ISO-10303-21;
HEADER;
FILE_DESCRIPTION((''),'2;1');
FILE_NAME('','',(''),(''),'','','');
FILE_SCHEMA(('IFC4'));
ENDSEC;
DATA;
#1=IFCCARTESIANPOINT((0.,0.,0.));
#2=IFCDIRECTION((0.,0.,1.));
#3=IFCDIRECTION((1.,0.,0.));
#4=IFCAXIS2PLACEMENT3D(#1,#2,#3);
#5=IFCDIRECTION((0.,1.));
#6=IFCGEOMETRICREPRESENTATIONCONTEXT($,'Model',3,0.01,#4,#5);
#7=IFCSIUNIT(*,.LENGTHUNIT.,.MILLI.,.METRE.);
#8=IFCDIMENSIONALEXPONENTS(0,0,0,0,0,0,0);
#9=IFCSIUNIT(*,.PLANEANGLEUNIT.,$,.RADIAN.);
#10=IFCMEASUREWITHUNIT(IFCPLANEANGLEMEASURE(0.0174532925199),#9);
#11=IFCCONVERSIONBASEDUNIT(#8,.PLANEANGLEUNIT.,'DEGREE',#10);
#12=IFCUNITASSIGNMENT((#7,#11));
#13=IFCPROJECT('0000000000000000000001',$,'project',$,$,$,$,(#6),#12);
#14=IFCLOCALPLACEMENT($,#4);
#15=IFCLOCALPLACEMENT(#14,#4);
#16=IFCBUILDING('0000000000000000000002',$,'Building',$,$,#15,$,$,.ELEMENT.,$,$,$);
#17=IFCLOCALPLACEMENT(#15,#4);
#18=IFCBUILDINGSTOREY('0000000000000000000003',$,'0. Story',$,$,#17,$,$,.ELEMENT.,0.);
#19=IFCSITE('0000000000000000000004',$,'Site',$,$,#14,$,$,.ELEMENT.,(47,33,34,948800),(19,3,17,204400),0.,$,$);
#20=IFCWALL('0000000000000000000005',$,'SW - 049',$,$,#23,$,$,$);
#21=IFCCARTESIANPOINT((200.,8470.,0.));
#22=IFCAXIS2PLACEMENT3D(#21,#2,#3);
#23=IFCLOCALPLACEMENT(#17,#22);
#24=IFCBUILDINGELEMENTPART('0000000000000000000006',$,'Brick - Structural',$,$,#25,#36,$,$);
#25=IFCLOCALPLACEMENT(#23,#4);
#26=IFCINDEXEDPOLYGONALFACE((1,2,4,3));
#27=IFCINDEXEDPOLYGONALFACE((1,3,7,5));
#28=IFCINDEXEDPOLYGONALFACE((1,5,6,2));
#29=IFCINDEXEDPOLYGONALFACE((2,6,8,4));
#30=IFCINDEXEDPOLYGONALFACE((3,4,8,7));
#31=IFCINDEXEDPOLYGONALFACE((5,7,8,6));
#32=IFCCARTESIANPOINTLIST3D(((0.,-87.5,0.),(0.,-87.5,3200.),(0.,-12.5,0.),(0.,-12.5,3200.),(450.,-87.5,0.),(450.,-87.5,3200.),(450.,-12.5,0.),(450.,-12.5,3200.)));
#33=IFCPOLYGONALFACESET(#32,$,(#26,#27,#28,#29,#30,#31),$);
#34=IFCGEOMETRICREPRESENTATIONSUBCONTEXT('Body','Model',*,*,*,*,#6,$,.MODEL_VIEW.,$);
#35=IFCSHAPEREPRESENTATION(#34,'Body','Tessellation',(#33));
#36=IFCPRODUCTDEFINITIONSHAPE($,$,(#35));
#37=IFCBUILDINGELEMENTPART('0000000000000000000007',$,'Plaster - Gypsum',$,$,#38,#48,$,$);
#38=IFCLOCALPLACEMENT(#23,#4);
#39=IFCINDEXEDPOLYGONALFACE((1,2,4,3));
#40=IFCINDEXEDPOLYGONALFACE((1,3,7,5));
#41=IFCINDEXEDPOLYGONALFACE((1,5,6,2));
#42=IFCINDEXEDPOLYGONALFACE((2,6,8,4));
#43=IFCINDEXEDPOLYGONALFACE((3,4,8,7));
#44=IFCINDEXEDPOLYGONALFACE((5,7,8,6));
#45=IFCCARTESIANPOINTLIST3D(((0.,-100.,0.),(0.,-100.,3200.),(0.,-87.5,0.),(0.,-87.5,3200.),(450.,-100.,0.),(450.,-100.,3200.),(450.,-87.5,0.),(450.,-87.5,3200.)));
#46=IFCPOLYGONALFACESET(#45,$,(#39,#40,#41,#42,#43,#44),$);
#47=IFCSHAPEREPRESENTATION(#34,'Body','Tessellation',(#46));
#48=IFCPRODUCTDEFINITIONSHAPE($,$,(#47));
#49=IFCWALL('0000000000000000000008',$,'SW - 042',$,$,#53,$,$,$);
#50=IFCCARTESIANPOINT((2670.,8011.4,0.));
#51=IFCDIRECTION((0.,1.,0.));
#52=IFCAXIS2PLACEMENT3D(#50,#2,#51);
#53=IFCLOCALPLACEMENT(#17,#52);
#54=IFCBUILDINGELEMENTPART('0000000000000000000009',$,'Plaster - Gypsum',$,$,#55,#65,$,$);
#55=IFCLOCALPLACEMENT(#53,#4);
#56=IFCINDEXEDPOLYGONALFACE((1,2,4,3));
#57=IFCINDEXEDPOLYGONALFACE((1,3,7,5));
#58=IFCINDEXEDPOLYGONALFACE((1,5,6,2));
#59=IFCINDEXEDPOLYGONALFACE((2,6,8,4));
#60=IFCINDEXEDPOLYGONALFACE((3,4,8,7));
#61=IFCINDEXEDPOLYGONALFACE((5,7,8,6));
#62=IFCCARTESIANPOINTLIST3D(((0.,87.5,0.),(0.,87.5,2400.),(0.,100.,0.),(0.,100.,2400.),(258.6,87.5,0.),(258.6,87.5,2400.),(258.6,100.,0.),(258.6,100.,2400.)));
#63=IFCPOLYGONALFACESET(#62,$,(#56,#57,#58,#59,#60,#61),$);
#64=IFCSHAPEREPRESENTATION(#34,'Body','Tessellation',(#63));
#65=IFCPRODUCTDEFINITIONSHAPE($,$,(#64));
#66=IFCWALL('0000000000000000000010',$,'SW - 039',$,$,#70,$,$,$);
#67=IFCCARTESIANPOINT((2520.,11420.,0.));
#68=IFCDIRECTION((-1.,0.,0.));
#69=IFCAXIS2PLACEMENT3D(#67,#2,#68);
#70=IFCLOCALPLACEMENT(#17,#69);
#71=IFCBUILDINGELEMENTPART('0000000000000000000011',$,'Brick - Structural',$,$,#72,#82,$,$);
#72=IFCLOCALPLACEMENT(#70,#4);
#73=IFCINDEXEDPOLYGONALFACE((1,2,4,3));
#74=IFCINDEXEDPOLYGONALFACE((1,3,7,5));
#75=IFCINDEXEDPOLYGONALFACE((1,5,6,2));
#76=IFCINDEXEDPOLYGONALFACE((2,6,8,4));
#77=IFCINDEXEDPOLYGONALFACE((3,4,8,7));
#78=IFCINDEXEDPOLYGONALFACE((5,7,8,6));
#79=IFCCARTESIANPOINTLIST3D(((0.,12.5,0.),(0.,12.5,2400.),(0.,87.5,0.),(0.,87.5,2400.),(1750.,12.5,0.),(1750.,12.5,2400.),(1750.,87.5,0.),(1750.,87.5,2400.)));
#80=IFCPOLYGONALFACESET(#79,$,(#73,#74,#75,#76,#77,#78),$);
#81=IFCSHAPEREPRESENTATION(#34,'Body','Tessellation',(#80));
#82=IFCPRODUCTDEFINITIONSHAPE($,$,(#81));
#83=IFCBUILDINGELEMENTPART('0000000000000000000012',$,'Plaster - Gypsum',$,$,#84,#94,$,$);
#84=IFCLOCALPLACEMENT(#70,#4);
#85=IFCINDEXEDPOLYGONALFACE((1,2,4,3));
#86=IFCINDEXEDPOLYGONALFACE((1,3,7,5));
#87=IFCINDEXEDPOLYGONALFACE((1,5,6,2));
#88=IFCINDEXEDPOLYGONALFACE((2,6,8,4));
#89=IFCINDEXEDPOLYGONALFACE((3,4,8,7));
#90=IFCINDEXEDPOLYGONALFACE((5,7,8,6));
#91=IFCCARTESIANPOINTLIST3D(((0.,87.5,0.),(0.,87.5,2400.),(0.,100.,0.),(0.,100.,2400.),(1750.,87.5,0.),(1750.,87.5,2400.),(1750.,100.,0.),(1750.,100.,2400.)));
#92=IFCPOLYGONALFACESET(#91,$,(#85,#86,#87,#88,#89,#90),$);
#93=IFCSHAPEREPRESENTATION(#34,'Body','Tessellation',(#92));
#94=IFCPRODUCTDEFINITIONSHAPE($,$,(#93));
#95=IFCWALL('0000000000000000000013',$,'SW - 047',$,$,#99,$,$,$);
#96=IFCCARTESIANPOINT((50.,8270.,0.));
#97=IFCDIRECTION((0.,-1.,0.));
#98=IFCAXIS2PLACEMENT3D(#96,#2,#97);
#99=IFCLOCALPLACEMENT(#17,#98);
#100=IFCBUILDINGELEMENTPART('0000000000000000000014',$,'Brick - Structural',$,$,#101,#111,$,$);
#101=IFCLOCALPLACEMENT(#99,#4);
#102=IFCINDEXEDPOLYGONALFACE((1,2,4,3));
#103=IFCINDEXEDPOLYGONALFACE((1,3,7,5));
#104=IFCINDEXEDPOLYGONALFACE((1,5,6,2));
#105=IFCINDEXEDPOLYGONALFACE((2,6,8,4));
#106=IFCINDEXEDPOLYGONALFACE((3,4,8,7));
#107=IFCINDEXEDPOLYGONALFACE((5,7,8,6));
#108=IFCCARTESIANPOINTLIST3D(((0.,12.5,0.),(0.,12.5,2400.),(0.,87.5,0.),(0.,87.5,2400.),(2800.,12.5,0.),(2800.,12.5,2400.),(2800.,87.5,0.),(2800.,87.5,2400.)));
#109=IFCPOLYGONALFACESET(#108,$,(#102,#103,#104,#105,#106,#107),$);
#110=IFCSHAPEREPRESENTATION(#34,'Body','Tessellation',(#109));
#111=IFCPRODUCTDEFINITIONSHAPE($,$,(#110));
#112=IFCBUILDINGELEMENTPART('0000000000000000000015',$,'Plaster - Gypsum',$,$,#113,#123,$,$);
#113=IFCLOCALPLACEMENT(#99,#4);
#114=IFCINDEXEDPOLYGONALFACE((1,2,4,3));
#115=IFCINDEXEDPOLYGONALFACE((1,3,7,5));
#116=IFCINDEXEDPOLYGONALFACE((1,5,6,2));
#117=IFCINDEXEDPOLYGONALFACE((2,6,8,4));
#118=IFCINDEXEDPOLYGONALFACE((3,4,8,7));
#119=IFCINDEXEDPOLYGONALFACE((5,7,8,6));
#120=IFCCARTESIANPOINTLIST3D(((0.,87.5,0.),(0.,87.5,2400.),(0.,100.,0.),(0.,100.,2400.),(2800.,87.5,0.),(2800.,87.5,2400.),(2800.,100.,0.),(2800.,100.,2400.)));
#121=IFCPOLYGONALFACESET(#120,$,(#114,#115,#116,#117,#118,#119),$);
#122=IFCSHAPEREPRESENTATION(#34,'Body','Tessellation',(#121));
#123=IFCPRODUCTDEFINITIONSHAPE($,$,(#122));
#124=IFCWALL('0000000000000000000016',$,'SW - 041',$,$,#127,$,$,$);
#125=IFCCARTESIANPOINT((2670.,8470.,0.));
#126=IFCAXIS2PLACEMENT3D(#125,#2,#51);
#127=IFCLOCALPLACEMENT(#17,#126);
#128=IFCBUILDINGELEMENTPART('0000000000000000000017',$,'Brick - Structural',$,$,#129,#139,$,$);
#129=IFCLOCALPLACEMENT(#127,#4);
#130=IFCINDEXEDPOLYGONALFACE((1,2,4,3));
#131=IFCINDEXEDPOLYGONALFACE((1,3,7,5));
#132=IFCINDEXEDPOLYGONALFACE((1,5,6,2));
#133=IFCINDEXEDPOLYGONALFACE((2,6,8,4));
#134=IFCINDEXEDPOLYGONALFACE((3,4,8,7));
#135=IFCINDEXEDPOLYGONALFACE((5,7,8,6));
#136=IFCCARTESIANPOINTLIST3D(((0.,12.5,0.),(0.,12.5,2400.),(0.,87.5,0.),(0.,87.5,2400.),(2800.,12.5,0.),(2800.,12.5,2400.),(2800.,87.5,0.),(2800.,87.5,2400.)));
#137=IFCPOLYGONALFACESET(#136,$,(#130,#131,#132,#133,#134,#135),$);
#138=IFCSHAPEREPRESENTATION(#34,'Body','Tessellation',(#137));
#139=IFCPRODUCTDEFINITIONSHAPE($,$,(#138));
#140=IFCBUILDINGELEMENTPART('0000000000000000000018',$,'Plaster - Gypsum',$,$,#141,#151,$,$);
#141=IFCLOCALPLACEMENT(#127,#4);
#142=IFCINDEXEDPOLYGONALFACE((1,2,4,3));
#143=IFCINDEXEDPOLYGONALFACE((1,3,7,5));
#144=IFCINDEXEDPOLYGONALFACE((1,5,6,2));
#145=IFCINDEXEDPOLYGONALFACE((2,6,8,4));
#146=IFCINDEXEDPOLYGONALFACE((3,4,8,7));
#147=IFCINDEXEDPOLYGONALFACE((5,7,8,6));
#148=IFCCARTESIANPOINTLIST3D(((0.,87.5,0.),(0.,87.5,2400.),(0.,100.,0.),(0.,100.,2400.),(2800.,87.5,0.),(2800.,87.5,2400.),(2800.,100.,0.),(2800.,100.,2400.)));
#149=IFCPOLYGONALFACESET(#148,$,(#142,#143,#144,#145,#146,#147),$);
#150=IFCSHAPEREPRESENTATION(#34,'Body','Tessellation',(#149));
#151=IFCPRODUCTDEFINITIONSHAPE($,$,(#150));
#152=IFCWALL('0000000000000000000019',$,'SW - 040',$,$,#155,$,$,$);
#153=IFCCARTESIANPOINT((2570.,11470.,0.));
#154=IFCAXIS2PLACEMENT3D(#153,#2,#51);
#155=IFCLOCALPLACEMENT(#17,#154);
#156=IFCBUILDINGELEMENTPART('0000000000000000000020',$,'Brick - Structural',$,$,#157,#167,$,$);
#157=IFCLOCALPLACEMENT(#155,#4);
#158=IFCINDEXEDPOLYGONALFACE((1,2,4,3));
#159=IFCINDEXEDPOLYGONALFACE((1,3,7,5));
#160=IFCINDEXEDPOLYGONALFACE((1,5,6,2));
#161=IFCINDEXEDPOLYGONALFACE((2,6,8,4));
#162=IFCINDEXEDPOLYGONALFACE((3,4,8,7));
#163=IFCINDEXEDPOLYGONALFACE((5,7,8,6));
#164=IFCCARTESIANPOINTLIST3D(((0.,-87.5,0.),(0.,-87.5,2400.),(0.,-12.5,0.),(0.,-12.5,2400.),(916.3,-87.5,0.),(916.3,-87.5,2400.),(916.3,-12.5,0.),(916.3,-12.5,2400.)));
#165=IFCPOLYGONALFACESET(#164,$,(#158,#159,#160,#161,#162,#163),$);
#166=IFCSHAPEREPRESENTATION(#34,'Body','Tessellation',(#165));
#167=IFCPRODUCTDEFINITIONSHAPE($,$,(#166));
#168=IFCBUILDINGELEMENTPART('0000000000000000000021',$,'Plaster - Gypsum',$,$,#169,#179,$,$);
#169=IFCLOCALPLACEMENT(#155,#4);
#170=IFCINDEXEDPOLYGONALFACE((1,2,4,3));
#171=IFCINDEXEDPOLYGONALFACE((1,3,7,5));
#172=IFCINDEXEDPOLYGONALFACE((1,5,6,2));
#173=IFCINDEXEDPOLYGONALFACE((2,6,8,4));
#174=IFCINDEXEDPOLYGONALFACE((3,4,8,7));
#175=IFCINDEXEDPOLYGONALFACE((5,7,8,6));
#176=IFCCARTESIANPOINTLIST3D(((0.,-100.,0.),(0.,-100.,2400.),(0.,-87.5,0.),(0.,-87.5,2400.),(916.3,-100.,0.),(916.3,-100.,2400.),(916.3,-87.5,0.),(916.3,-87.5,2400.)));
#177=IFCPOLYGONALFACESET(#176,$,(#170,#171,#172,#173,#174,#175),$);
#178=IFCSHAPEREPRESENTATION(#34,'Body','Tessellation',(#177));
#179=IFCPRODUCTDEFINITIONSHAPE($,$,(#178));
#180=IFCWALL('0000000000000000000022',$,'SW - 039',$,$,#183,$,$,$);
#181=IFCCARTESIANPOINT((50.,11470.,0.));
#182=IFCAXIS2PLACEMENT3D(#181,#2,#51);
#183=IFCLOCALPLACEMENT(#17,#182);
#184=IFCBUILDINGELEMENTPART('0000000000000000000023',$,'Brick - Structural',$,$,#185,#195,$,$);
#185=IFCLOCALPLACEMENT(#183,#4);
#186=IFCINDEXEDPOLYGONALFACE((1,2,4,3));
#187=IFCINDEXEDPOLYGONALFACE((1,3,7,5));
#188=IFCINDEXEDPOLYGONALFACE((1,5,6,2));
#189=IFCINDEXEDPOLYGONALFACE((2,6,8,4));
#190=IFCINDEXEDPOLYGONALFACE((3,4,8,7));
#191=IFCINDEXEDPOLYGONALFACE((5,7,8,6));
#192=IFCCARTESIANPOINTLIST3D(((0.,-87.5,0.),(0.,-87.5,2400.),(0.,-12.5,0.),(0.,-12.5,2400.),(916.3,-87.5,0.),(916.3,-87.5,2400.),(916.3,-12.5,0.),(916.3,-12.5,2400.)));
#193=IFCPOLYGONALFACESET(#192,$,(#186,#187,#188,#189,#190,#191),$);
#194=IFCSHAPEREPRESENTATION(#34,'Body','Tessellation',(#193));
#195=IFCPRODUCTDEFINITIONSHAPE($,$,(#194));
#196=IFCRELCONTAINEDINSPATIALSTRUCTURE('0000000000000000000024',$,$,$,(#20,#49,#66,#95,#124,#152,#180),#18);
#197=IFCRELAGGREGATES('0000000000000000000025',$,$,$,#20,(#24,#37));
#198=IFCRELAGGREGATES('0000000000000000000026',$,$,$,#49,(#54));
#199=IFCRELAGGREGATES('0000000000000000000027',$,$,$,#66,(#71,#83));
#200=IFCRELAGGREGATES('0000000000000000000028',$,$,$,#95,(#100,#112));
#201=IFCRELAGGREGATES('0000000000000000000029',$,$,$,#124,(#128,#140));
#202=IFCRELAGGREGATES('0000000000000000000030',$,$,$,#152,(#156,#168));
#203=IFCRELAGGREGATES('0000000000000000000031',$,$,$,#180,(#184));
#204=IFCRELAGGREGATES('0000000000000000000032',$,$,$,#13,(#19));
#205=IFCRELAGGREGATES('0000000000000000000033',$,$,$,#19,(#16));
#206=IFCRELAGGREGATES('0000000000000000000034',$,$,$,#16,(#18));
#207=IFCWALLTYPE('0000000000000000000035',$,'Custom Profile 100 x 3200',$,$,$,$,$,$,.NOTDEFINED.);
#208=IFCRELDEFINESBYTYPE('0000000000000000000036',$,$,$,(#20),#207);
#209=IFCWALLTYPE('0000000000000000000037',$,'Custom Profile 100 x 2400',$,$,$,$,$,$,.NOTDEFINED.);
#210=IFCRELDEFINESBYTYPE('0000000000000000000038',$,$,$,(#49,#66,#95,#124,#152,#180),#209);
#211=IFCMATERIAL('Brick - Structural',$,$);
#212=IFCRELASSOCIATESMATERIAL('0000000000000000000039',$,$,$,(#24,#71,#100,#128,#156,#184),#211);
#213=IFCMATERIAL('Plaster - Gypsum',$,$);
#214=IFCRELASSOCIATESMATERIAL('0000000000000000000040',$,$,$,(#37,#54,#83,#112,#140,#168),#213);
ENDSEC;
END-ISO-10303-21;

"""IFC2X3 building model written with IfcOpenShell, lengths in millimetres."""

from ifc_helpers import new_model, entity, si_unit, converted_unit, direction, frame, origin_with_axes, place, context, subcontext, project, spatial, polyline, outline, extrude, material, type_object, element, aggregate, save


model = new_model("IFC2X3")

# Units and contexts
model_context = context("Model", 3, precision=0.01, world=origin_with_axes(), true_north=direction((0.0, 1.0)))
body_context = subcontext(model_context, "Body", "Model", "MODEL_VIEW")
ifc_project = project(units=[si_unit("LENGTHUNIT", "METRE", prefix="MILLI"), converted_unit("PLANEANGLEUNIT", "DEGREE", entity("IfcPlaneAngleMeasure", 0.0174532925199), si_unit("PLANEANGLEUNIT", "RADIAN"), dimensions=[0, 0, 0, 0, 0, 0, 0])], contexts=[model_context])

# Site, building, storey
site_placement = place(None, origin_with_axes())
site = spatial("IfcSite", under=ifc_project, at=site_placement, Name="Site", CompositionType="ELEMENT", RefLatitude=(47, 33, 34, 948800), RefLongitude=(19, 3, 17, 204400), RefElevation=0.0)
building_placement = place(site_placement, origin_with_axes())
building = spatial("IfcBuilding", under=site, at=building_placement, Name="Building", CompositionType="ELEMENT")
storey_placement = place(building_placement, origin_with_axes())
storey = spatial("IfcBuildingStorey", under=building, at=storey_placement, Name="0. Story", CompositionType="ELEMENT", Elevation=0.0)

# Wall, building element parts
wall_type_1 = type_object("IfcWallType", Name="Custom Profile 100 x 3200", PredefinedType="NOTDEFINED")
wall_1_placement = place(storey_placement, frame((200.0, 8470.0, 0.0), z_axis=(0.0, 0.0, 1.0), x_axis=(1.0, 0.0, 0.0)))
wall_1 = element("IfcWall", 1, at=wall_1_placement, inside=storey, type_object=wall_type_1, Name="SW - 049")
ifc_material_1 = material(Name="Plaster - Gypsum")
ifc_material_2 = material(Name="Brick - Structural")
building_element_part_1_placement = place(wall_1_placement, origin_with_axes())
building_element_part_1 = element("IfcBuildingElementPart", 2, at=building_element_part_1_placement, material=ifc_material_2, Name="Brick - Structural", context=body_context, shape_type="SweptSolid", body=[
    extrude(outline(polyline([(-87.5, 0.0), (-12.5, 0.0), (-12.5, 3200.0), (-87.5, 3200.0), (-87.5, 0.0)])), frame((0.0, 0.0, 0.0), z_axis=(1.0, 0.0, 0.0), x_axis=(0.0, 1.0, 0.0)), (0.0, 0.0, 1.0), 450.0),
])
building_element_part_2_placement = place(wall_1_placement, origin_with_axes())
building_element_part_2 = element("IfcBuildingElementPart", 3, at=building_element_part_2_placement, material=ifc_material_1, Name="Plaster - Gypsum", context=body_context, shape_type="SweptSolid", body=[
    extrude(outline(polyline([(-100.0, 3200.0), (-100.0, 0.0), (-87.5, 0.0), (-87.5, 3200.0), (-100.0, 3200.0)])), frame((0.0, 0.0, 0.0), z_axis=(1.0, 0.0, 0.0), x_axis=(0.0, 1.0, 0.0)), (0.0, 0.0, 1.0), 450.0),
])
aggregate(wall_1, [building_element_part_1, building_element_part_2])

# Wall, building element part
wall_type_2 = type_object("IfcWallType", Name="Custom Profile 100 x 2400", PredefinedType="NOTDEFINED")
wall_2_placement = place(storey_placement, frame((2670.0, 8011.4, 0.0), z_axis=(0.0, 0.0, 1.0), x_axis=(0.0, 1.0, 0.0)))
wall_2 = element("IfcWall", 4, at=wall_2_placement, inside=storey, type_object=wall_type_2, Name="SW - 042")
building_element_part_3_placement = place(wall_2_placement, origin_with_axes())
building_element_part_3 = element("IfcBuildingElementPart", 5, at=building_element_part_3_placement, material=ifc_material_1, Name="Plaster - Gypsum", context=body_context, shape_type="SweptSolid", body=[
    extrude(outline(polyline([(-100.0, 2400.0), (-100.0, 0.0), (-87.5, 0.0), (-87.5, 2400.0), (-100.0, 2400.0)])), frame((0.0, 0.0, 0.0), z_axis=(-1.0, 0.0, 0.0), x_axis=(0.0, -1.0, 0.0)), (0.0, 0.0, -1.0), 258.6),
])
aggregate(wall_2, [building_element_part_3])

# Walls, building element parts
wall_3_placement = place(storey_placement, frame((2520.0, 11420.0, 0.0), z_axis=(0.0, 0.0, 1.0), x_axis=(-1.0, 0.0, 0.0)))
wall_3 = element("IfcWall", 6, at=wall_3_placement, inside=storey, type_object=wall_type_2, Name="SW - 039")
building_element_part_4_placement = place(wall_3_placement, origin_with_axes())
building_element_part_4 = element("IfcBuildingElementPart", 7, at=building_element_part_4_placement, material=ifc_material_2, Name="Brick - Structural", context=body_context, shape_type="SweptSolid", body=[
    extrude(outline(polyline([(-87.5, 0.0), (-12.5, 0.0), (-12.5, 2400.0), (-87.5, 2400.0), (-87.5, 0.0)])), frame((0.0, 0.0, 0.0), z_axis=(-1.0, 0.0, 0.0), x_axis=(0.0, -1.0, 0.0)), (0.0, 0.0, -1.0), 1750.0),
])
building_element_part_5_placement = place(wall_3_placement, origin_with_axes())
building_element_part_5 = element("IfcBuildingElementPart", 8, at=building_element_part_5_placement, material=ifc_material_1, Name="Plaster - Gypsum", context=body_context, shape_type="SweptSolid", body=[
    extrude(outline(polyline([(-100.0, 2400.0), (-100.0, 0.0), (-87.5, 0.0), (-87.5, 2400.0), (-100.0, 2400.0)])), frame((0.0, 0.0, 0.0), z_axis=(-1.0, 0.0, 0.0), x_axis=(0.0, -1.0, 0.0)), (0.0, 0.0, -1.0), 1750.0),
])
aggregate(wall_3, [building_element_part_4, building_element_part_5])
wall_4_placement = place(storey_placement, frame((50.0, 8270.0, 0.0), z_axis=(0.0, 0.0, 1.0), x_axis=(0.0, -1.0, 0.0)))
wall_4 = element("IfcWall", 9, at=wall_4_placement, inside=storey, type_object=wall_type_2, Name="SW - 047")
building_element_part_6_placement = place(wall_4_placement, origin_with_axes())
building_element_part_6 = element("IfcBuildingElementPart", 10, at=building_element_part_6_placement, material=ifc_material_2, Name="Brick - Structural", context=body_context, shape_type="SweptSolid", body=[
    extrude(outline(polyline([(-87.5, 0.0), (-12.5, 0.0), (-12.5, 2400.0), (-87.5, 2400.0), (-87.5, 0.0)])), frame((0.0, 0.0, 0.0), z_axis=(-1.0, 0.0, 0.0), x_axis=(0.0, -1.0, 0.0)), (0.0, 0.0, -1.0), 2800.0),
])
building_element_part_7_placement = place(wall_4_placement, origin_with_axes())
building_element_part_7 = element("IfcBuildingElementPart", 11, at=building_element_part_7_placement, material=ifc_material_1, Name="Plaster - Gypsum", context=body_context, shape_type="SweptSolid", body=[
    extrude(outline(polyline([(-100.0, 2400.0), (-100.0, 0.0), (-87.5, 0.0), (-87.5, 2400.0), (-100.0, 2400.0)])), frame((0.0, 0.0, 0.0), z_axis=(-1.0, 0.0, 0.0), x_axis=(0.0, -1.0, 0.0)), (0.0, 0.0, -1.0), 2800.0),
])
aggregate(wall_4, [building_element_part_6, building_element_part_7])
wall_5_placement = place(storey_placement, frame((2670.0, 8470.0, 0.0), z_axis=(0.0, 0.0, 1.0), x_axis=(0.0, 1.0, 0.0)))
wall_5 = element("IfcWall", 12, at=wall_5_placement, inside=storey, type_object=wall_type_2, Name="SW - 041")
building_element_part_8_placement = place(wall_5_placement, origin_with_axes())
building_element_part_8 = element("IfcBuildingElementPart", 13, at=building_element_part_8_placement, material=ifc_material_2, Name="Brick - Structural", context=body_context, shape_type="SweptSolid", body=[
    extrude(outline(polyline([(-87.5, 0.0), (-12.5, 0.0), (-12.5, 2400.0), (-87.5, 2400.0), (-87.5, 0.0)])), frame((0.0, 0.0, 0.0), z_axis=(-1.0, 0.0, 0.0), x_axis=(0.0, -1.0, 0.0)), (0.0, 0.0, -1.0), 2800.0),
])
building_element_part_9_placement = place(wall_5_placement, origin_with_axes())
building_element_part_9 = element("IfcBuildingElementPart", 14, at=building_element_part_9_placement, material=ifc_material_1, Name="Plaster - Gypsum", context=body_context, shape_type="SweptSolid", body=[
    extrude(outline(polyline([(-100.0, 2400.0), (-100.0, 0.0), (-87.5, 0.0), (-87.5, 2400.0), (-100.0, 2400.0)])), frame((0.0, 0.0, 0.0), z_axis=(-1.0, 0.0, 0.0), x_axis=(0.0, -1.0, 0.0)), (0.0, 0.0, -1.0), 2800.0),
])
aggregate(wall_5, [building_element_part_8, building_element_part_9])
wall_6_placement = place(storey_placement, frame((2570.0, 11470.0, 0.0), z_axis=(0.0, 0.0, 1.0), x_axis=(0.0, 1.0, 0.0)))
wall_6 = element("IfcWall", 15, at=wall_6_placement, inside=storey, type_object=wall_type_2, Name="SW - 040")
building_element_part_10_placement = place(wall_6_placement, origin_with_axes())
building_element_part_10 = element("IfcBuildingElementPart", 16, at=building_element_part_10_placement, material=ifc_material_2, Name="Brick - Structural", context=body_context, shape_type="SweptSolid", body=[
    extrude(outline(polyline([(-87.5, 0.0), (-12.5, 0.0), (-12.5, 2400.0), (-87.5, 2400.0), (-87.5, 0.0)])), frame((0.0, 0.0, 0.0), z_axis=(1.0, 0.0, 0.0), x_axis=(0.0, 1.0, 0.0)), (0.0, 0.0, 1.0), 916.3),
])
building_element_part_11_placement = place(wall_6_placement, origin_with_axes())
building_element_part_11 = element("IfcBuildingElementPart", 17, at=building_element_part_11_placement, material=ifc_material_1, Name="Plaster - Gypsum", context=body_context, shape_type="SweptSolid", body=[
    extrude(outline(polyline([(-100.0, 2400.0), (-100.0, 0.0), (-87.5, 0.0), (-87.5, 2400.0), (-100.0, 2400.0)])), frame((0.0, 0.0, 0.0), z_axis=(1.0, 0.0, 0.0), x_axis=(0.0, 1.0, 0.0)), (0.0, 0.0, 1.0), 916.3),
])
aggregate(wall_6, [building_element_part_10, building_element_part_11])
wall_7_placement = place(storey_placement, frame((50.0, 11470.0, 0.0), z_axis=(0.0, 0.0, 1.0), x_axis=(0.0, 1.0, 0.0)))
wall_7 = element("IfcWall", 18, at=wall_7_placement, inside=storey, type_object=wall_type_2, Name="SW - 039")
building_element_part_12_placement = place(wall_7_placement, origin_with_axes())
building_element_part_12 = element("IfcBuildingElementPart", 19, at=building_element_part_12_placement, material=ifc_material_2, Name="Brick - Structural", context=body_context, shape_type="SweptSolid", body=[
    extrude(outline(polyline([(-87.5, 0.0), (-12.5, 0.0), (-12.5, 2400.0), (-87.5, 2400.0), (-87.5, 0.0)])), frame((0.0, 0.0, 0.0), z_axis=(1.0, 0.0, 0.0), x_axis=(0.0, 1.0, 0.0)), (0.0, 0.0, 1.0), 916.3),
])
aggregate(wall_7, [building_element_part_12])

save(model, "model.ifc")
